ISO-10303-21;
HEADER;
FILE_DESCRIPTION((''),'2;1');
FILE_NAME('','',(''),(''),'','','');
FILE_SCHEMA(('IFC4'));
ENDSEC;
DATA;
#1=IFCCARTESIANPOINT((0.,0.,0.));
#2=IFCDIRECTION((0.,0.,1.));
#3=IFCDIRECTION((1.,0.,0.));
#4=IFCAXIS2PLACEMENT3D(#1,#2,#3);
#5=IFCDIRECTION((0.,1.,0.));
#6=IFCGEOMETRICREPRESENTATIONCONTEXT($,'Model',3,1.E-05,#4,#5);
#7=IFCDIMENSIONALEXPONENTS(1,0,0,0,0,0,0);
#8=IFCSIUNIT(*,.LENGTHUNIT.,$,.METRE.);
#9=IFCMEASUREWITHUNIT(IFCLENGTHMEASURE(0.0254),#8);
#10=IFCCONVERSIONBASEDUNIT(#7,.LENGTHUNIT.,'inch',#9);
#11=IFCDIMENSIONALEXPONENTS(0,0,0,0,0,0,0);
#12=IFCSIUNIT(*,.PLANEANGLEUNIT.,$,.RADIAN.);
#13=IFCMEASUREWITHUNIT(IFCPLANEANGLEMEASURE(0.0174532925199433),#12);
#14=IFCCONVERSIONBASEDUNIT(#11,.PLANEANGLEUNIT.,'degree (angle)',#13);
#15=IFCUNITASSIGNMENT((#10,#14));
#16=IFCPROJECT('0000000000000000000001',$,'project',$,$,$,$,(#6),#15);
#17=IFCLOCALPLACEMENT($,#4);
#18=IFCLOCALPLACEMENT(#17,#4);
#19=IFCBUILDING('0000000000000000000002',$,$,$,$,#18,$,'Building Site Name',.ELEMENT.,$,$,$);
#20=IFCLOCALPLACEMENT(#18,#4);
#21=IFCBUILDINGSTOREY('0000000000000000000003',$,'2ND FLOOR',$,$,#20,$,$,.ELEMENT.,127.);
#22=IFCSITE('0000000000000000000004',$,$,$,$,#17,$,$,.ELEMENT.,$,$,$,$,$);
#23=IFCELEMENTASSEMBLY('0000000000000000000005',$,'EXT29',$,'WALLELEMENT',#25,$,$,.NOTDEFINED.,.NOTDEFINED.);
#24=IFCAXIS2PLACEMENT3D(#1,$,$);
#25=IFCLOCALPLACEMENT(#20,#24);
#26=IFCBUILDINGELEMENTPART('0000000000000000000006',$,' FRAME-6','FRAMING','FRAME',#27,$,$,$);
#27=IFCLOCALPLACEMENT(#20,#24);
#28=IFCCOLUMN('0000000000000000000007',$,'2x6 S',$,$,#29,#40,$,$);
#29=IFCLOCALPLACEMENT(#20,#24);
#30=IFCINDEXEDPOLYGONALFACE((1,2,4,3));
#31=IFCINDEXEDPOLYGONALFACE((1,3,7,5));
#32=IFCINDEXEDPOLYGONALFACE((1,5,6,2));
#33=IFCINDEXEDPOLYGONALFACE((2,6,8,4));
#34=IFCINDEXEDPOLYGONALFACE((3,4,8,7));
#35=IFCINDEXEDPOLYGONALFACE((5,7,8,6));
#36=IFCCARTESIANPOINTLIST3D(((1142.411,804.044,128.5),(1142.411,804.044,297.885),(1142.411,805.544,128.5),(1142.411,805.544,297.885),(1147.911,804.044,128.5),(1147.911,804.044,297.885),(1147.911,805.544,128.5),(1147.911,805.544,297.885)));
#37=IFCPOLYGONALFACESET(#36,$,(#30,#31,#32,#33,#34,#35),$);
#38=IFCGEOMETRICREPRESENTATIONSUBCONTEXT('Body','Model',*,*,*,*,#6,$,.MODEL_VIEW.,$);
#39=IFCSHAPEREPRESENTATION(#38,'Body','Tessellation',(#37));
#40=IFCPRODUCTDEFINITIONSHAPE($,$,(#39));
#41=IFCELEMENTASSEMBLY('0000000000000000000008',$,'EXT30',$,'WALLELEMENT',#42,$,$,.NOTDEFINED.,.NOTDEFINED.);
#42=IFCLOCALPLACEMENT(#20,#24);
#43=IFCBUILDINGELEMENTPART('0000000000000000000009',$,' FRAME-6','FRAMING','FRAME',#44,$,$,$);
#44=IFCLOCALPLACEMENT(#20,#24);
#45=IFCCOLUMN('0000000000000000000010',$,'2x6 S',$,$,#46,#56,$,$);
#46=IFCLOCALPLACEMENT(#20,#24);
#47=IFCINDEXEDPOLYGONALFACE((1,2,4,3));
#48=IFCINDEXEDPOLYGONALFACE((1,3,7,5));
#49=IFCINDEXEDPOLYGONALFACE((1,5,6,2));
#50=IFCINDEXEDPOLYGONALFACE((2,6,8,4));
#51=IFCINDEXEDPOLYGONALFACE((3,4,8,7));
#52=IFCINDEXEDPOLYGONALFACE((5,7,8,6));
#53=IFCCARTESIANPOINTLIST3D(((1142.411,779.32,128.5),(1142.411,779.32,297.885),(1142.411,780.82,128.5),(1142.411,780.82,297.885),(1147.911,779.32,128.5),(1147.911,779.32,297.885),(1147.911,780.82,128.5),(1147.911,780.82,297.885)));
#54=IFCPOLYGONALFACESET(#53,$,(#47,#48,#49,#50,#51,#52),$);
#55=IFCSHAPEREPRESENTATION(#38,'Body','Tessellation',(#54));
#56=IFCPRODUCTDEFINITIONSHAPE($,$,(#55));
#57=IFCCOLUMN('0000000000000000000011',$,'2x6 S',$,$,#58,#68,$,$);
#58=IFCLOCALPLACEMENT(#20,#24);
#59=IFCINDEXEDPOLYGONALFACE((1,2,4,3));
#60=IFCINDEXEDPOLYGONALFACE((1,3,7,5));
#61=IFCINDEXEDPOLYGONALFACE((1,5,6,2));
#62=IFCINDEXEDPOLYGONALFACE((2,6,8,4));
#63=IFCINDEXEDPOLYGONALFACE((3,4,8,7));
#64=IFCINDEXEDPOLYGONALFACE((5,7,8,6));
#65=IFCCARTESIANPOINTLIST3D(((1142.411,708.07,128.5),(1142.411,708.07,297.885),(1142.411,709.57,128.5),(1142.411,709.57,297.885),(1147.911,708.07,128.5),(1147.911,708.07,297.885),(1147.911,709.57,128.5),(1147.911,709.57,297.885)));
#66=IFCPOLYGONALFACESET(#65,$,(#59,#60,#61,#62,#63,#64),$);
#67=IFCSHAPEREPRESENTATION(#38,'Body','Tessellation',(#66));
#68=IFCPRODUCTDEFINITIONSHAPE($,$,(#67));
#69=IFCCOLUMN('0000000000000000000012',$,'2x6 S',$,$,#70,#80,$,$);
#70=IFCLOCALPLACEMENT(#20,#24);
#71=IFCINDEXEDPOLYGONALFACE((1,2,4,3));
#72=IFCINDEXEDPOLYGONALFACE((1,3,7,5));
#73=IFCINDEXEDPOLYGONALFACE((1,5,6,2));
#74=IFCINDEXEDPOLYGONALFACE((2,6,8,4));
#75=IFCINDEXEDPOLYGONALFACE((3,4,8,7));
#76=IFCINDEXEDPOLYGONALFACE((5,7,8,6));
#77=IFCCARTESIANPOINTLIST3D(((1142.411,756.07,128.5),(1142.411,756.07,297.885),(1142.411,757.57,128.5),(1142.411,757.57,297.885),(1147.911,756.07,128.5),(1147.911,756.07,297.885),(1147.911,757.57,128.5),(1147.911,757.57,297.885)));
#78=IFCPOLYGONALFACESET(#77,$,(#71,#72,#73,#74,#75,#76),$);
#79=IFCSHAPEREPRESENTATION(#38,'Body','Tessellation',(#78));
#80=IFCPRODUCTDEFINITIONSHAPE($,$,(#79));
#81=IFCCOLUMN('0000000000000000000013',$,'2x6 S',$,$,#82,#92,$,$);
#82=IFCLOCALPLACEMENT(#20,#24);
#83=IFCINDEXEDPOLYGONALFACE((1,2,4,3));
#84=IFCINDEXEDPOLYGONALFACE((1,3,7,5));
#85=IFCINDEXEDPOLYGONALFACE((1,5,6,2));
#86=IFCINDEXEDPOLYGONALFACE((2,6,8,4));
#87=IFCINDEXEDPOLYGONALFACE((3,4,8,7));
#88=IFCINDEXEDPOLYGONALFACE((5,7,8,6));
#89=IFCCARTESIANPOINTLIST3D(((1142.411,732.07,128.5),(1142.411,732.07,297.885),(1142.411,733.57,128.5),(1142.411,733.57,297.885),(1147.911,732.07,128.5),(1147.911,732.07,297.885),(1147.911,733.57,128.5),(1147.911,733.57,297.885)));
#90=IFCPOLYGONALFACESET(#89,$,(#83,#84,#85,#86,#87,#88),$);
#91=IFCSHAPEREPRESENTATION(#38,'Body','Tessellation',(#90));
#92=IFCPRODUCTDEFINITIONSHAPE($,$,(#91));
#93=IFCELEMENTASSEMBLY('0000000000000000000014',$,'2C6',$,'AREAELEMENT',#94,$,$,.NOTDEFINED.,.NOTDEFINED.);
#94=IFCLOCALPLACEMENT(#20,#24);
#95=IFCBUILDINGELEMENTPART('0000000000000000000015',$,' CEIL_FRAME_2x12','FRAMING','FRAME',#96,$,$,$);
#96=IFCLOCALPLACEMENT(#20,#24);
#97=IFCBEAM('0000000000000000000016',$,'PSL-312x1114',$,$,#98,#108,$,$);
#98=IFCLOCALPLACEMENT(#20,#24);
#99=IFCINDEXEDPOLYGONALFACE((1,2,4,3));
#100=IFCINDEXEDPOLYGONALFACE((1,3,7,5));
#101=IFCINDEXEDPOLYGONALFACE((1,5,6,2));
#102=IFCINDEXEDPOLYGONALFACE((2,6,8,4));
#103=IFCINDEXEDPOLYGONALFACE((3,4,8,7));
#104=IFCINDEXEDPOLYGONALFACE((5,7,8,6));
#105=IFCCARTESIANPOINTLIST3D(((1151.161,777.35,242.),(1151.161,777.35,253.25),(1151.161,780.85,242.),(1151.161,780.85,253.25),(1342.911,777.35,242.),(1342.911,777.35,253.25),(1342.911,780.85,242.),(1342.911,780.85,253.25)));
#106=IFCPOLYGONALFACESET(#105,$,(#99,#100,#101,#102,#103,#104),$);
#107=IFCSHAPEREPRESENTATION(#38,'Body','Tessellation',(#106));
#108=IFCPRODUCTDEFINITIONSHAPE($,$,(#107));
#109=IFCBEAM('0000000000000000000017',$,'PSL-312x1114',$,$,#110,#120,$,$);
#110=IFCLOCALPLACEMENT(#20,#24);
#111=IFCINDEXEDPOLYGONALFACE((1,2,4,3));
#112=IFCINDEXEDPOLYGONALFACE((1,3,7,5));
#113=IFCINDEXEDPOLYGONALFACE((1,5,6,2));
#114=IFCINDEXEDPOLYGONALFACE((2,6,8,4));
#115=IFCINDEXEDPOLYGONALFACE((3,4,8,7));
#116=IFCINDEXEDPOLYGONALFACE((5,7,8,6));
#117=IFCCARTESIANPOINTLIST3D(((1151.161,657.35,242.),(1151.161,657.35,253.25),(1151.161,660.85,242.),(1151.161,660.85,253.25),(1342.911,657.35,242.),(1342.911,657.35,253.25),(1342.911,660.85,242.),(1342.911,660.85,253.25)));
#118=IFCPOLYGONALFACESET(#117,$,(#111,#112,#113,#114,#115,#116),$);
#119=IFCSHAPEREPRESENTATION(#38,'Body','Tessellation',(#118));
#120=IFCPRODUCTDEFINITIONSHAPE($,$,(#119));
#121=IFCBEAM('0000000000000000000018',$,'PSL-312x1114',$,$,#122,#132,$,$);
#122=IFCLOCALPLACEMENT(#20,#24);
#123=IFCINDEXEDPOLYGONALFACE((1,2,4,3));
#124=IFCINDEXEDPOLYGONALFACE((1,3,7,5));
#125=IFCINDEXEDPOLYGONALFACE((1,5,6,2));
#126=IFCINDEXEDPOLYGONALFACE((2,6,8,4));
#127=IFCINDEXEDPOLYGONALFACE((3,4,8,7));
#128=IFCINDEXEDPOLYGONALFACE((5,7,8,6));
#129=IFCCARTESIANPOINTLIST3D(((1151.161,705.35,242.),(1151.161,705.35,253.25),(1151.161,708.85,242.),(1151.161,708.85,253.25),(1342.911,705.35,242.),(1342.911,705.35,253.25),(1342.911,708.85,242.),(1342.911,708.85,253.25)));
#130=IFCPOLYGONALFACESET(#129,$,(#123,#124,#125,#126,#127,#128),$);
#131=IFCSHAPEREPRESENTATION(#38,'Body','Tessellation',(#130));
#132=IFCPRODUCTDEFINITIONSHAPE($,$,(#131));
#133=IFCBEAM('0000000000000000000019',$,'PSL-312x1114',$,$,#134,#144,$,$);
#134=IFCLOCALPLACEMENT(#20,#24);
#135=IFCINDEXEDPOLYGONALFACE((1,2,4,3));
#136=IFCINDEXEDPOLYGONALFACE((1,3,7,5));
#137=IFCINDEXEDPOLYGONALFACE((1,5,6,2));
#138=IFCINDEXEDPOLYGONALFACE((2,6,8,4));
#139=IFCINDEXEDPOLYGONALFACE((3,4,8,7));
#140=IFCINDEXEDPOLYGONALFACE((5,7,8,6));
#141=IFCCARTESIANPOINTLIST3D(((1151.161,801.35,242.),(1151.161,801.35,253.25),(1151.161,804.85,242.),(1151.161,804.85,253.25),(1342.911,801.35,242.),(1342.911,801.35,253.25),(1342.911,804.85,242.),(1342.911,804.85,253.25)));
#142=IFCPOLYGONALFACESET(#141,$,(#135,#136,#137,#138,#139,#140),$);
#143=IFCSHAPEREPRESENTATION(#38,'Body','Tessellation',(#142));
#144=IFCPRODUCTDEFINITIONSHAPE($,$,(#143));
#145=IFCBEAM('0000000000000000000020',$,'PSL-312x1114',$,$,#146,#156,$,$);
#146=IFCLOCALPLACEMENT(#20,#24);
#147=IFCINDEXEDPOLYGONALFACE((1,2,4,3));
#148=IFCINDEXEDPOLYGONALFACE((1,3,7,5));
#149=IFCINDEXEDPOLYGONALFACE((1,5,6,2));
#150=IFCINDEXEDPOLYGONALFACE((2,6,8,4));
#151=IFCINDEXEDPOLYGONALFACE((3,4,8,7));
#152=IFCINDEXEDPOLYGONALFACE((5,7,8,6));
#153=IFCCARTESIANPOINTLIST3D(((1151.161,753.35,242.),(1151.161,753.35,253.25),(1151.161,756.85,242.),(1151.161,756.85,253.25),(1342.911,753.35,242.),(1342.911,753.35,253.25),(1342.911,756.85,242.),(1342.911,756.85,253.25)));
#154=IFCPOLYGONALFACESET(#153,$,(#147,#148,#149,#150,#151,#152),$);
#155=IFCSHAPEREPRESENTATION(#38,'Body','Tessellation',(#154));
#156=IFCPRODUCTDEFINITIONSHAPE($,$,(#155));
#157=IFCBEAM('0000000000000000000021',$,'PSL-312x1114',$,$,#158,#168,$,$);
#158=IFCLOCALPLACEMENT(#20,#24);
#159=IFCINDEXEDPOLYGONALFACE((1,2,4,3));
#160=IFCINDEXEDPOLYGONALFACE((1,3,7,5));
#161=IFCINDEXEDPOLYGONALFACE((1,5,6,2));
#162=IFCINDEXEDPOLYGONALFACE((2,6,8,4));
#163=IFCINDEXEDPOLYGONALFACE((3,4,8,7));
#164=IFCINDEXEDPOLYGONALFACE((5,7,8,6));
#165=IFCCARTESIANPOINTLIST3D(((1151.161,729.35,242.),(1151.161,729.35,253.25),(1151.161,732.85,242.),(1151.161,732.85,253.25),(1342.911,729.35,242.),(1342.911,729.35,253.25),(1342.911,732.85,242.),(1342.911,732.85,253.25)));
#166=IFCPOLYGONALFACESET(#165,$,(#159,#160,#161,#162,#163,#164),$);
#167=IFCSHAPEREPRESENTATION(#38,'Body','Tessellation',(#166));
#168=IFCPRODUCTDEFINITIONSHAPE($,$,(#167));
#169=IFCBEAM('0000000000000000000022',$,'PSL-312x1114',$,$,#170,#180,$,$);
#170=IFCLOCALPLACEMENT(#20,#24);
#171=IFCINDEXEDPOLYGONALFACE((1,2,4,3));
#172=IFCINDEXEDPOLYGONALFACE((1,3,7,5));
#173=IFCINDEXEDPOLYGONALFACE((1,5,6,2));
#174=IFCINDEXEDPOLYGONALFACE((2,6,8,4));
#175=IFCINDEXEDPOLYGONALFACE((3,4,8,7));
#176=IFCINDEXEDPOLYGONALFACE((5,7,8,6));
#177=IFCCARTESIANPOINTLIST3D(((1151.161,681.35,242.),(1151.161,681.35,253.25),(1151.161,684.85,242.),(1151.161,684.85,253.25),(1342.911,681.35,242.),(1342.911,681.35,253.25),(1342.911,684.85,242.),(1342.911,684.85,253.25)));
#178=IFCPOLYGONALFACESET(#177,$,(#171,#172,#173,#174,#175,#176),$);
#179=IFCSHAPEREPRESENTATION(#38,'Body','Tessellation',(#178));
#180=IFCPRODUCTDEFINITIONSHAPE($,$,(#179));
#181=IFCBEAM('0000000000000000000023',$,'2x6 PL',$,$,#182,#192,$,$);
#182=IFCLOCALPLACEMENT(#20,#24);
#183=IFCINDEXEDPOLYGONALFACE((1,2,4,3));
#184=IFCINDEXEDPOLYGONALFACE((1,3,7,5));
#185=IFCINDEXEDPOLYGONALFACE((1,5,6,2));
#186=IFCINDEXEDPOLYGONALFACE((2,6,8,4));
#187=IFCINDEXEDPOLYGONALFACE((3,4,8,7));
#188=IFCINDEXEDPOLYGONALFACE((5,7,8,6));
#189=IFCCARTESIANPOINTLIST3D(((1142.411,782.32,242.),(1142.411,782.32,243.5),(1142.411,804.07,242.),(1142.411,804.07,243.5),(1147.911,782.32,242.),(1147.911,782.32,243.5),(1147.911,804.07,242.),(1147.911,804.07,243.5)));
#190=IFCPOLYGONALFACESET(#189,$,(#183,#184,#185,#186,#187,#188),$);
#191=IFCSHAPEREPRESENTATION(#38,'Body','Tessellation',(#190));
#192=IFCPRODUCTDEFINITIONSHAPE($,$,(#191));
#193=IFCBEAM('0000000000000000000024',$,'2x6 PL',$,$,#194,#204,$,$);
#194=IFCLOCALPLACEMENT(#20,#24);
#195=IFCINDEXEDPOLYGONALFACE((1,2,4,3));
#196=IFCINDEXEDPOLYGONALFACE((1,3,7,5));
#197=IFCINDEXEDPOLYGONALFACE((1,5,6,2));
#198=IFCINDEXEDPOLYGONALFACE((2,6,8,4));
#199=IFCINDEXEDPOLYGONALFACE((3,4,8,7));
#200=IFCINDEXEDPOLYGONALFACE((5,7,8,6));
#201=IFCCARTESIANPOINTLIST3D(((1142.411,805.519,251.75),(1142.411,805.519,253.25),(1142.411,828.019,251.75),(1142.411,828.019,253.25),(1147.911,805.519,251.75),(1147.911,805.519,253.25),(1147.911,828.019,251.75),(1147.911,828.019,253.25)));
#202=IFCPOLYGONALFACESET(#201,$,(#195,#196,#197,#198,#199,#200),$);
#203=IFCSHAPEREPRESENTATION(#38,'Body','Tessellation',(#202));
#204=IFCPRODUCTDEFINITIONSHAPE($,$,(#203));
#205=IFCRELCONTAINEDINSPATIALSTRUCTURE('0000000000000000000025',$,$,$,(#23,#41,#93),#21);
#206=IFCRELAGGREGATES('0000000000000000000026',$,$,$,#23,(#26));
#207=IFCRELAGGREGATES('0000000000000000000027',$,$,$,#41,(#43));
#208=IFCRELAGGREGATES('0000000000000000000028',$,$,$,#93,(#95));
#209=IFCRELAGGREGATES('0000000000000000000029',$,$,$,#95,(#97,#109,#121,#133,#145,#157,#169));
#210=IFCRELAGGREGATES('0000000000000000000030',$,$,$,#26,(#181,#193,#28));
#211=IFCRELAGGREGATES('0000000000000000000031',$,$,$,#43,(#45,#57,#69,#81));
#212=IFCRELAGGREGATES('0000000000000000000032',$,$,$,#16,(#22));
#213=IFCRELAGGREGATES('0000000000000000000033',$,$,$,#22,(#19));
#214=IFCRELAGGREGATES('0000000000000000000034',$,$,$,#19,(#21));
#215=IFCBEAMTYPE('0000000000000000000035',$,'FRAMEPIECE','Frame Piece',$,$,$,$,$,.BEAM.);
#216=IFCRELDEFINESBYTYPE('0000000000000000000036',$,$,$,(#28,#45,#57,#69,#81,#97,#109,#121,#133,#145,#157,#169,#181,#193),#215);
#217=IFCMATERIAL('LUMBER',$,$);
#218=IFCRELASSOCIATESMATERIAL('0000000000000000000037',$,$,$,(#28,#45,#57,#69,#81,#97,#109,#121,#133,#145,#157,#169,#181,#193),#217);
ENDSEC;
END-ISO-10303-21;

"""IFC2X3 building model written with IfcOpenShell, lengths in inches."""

from ifc_helpers import new_model, entity, si_unit, converted_unit, direction, frame, frame_2d, origin_with_axes, place, context, subcontext, project, spatial, rectangle, extrude, material, type_object, element, aggregate, save


model = new_model("IFC2X3")

# Units and contexts
model_context = context("Model", 3, precision=1e-05, world=origin_with_axes(), true_north=direction((0.0, 1.0, 0.0)))
body_context = subcontext(model_context, "Body", "Model", "MODEL_VIEW")
ifc_project = project(units=[converted_unit("LENGTHUNIT", "inch", entity("IfcLengthMeasure", 0.0254), si_unit("LENGTHUNIT", "METRE"), dimensions=[1, 0, 0, 0, 0, 0, 0]), converted_unit("PLANEANGLEUNIT", "degree (angle)", entity("IfcPlaneAngleMeasure", 0.0174532925199433), si_unit("PLANEANGLEUNIT", "RADIAN"), dimensions=[0, 0, 0, 0, 0, 0, 0])], contexts=[model_context])

# Site, building, storey
site_placement = place(None, origin_with_axes())
site = spatial("IfcSite", under=ifc_project, at=site_placement, CompositionType="ELEMENT")
building_placement = place(site_placement, origin_with_axes())
building = spatial("IfcBuilding", under=site, at=building_placement, LongName="Building Site Name", CompositionType="ELEMENT")
storey_placement = place(building_placement, origin_with_axes())
storey = spatial("IfcBuildingStorey", under=building, at=storey_placement, Name="2ND FLOOR", CompositionType="ELEMENT", Elevation=127.0)

# Element assembly, building element part, column
assembly_1_placement = place(storey_placement, origin_with_axes())
assembly_1 = element("IfcElementAssembly", 1, at=assembly_1_placement, inside=storey, Name="EXT29", ObjectType="WALLELEMENT", AssemblyPlace="NOTDEFINED", PredefinedType="NOTDEFINED")
building_element_part_1 = element("IfcBuildingElementPart", 2, Name=" FRAME-6", Description="FRAMING", ObjectType="FRAME")
aggregate(assembly_1, [building_element_part_1])
ifc_material = material(Name="LUMBER")
beam_type = type_object("IfcBeamType", Name="FRAMEPIECE", Description="Frame Piece", PredefinedType="BEAM")
column_1_placement = place(assembly_1_placement, frame((1145.161, 804.794, 297.885), z_axis=(0.0, 0.0, -1.0), x_axis=(0.0, -1.0, 0.0)))
column_1 = element("IfcColumn", 3, at=column_1_placement, type_object=beam_type, material=ifc_material, Name="2x6 S", context=body_context, shape_type="SweptSolid", body=[
    extrude(rectangle(XDim=1.5, YDim=5.5, at=frame_2d((0.0, 0.0), x_axis=(-1.0, 0.0))), origin_with_axes(), (0.0, 0.0, 1.0), 169.385),
])

# Element assembly, building element part, columns
assembly_2_placement = place(storey_placement, origin_with_axes())
assembly_2 = element("IfcElementAssembly", 4, at=assembly_2_placement, inside=storey, Name="EXT30", ObjectType="WALLELEMENT", AssemblyPlace="NOTDEFINED", PredefinedType="NOTDEFINED")
building_element_part_2 = element("IfcBuildingElementPart", 5, Name=" FRAME-6", Description="FRAMING", ObjectType="FRAME")
aggregate(assembly_2, [building_element_part_2])
column_2_placement = place(assembly_2_placement, frame((1145.161, 780.07, 297.885), z_axis=(0.0, 0.0, -1.0), x_axis=(0.0, -1.0, 0.0)))
column_2 = element("IfcColumn", 6, at=column_2_placement, type_object=beam_type, material=ifc_material, Name="2x6 S", context=body_context, shape_type="SweptSolid", body=[
    extrude(rectangle(XDim=1.5, YDim=5.5, at=frame_2d((0.0, 0.0), x_axis=(-1.0, 0.0))), origin_with_axes(), (0.0, 0.0, 1.0), 169.385),
])
column_3_placement = place(assembly_2_placement, frame((1145.161, 708.82, 297.885), z_axis=(0.0, 0.0, -1.0), x_axis=(0.0, -1.0, 0.0)))
column_3 = element("IfcColumn", 7, at=column_3_placement, type_object=beam_type, material=ifc_material, Name="2x6 S", context=body_context, shape_type="SweptSolid", body=[
    extrude(rectangle(XDim=1.5, YDim=5.5, at=frame_2d((0.0, 0.0), x_axis=(-1.0, 0.0))), origin_with_axes(), (0.0, 0.0, 1.0), 169.385),
])
column_4_placement = place(assembly_2_placement, frame((1145.161, 756.82, 297.885), z_axis=(0.0, 0.0, -1.0), x_axis=(0.0, -1.0, 0.0)))
column_4 = element("IfcColumn", 8, at=column_4_placement, type_object=beam_type, material=ifc_material, Name="2x6 S", context=body_context, shape_type="SweptSolid", body=[
    extrude(rectangle(XDim=1.5, YDim=5.5, at=frame_2d((0.0, 0.0), x_axis=(-1.0, 0.0))), origin_with_axes(), (0.0, 0.0, 1.0), 169.385),
])
column_5_placement = place(assembly_2_placement, frame((1145.161, 732.82, 297.885), z_axis=(0.0, 0.0, -1.0), x_axis=(0.0, -1.0, 0.0)))
column_5 = element("IfcColumn", 9, at=column_5_placement, type_object=beam_type, material=ifc_material, Name="2x6 S", context=body_context, shape_type="SweptSolid", body=[
    extrude(rectangle(XDim=1.5, YDim=5.5, at=frame_2d((0.0, 0.0), x_axis=(-1.0, 0.0))), origin_with_axes(), (0.0, 0.0, 1.0), 169.385),
])

# Element assembly, building element part, beams
assembly_3_placement = place(storey_placement, origin_with_axes())
assembly_3 = element("IfcElementAssembly", 10, at=assembly_3_placement, inside=storey, Name="2C6", ObjectType="AREAELEMENT", AssemblyPlace="NOTDEFINED", PredefinedType="NOTDEFINED")
building_element_part_3 = element("IfcBuildingElementPart", 11, Name=" CEIL_FRAME_2x12", Description="FRAMING", ObjectType="FRAME")
aggregate(assembly_3, [building_element_part_3])
beam_1_placement = place(assembly_3_placement, frame((1151.161, 779.1, 247.625), z_axis=(1.0, 0.0, 0.0), x_axis=(0.0, 1.0, 0.0)))
beam_1 = element("IfcBeam", 12, at=beam_1_placement, type_object=beam_type, material=ifc_material, Name="PSL-312x1114", context=body_context, shape_type="SweptSolid", body=[
    extrude(rectangle(XDim=3.5, YDim=11.25, at=frame_2d((0.0, 0.0), x_axis=(-1.0, 0.0))), origin_with_axes(), (0.0, 0.0, 1.0), 191.75),
])
beam_2_placement = place(assembly_3_placement, frame((1151.161, 659.1, 247.625), z_axis=(1.0, 0.0, 0.0), x_axis=(0.0, 1.0, 0.0)))
beam_2 = element("IfcBeam", 13, at=beam_2_placement, type_object=beam_type, material=ifc_material, Name="PSL-312x1114", context=body_context, shape_type="SweptSolid", body=[
    extrude(rectangle(XDim=3.5, YDim=11.25, at=frame_2d((0.0, 0.0), x_axis=(-1.0, 0.0))), origin_with_axes(), (0.0, 0.0, 1.0), 191.75),
])
beam_3_placement = place(assembly_3_placement, frame((1151.161, 707.1, 247.625), z_axis=(1.0, 0.0, 0.0), x_axis=(0.0, 1.0, 0.0)))
beam_3 = element("IfcBeam", 14, at=beam_3_placement, type_object=beam_type, material=ifc_material, Name="PSL-312x1114", context=body_context, shape_type="SweptSolid", body=[
    extrude(rectangle(XDim=3.5, YDim=11.25, at=frame_2d((0.0, 0.0), x_axis=(-1.0, 0.0))), origin_with_axes(), (0.0, 0.0, 1.0), 191.75),
])
beam_4_placement = place(assembly_3_placement, frame((1151.161, 803.1, 247.625), z_axis=(1.0, 0.0, 0.0), x_axis=(0.0, 1.0, 0.0)))
beam_4 = element("IfcBeam", 15, at=beam_4_placement, type_object=beam_type, material=ifc_material, Name="PSL-312x1114", context=body_context, shape_type="SweptSolid", body=[
    extrude(rectangle(XDim=3.5, YDim=11.25, at=frame_2d((0.0, 0.0), x_axis=(-1.0, 0.0))), origin_with_axes(), (0.0, 0.0, 1.0), 191.75),
])
beam_5_placement = place(assembly_3_placement, frame((1151.161, 755.1, 247.625), z_axis=(1.0, 0.0, 0.0), x_axis=(0.0, 1.0, 0.0)))
beam_5 = element("IfcBeam", 16, at=beam_5_placement, type_object=beam_type, material=ifc_material, Name="PSL-312x1114", context=body_context, shape_type="SweptSolid", body=[
    extrude(rectangle(XDim=3.5, YDim=11.25, at=frame_2d((0.0, 0.0), x_axis=(-1.0, 0.0))), origin_with_axes(), (0.0, 0.0, 1.0), 191.75),
])
beam_6_placement = place(assembly_3_placement, frame((1151.161, 731.1, 247.625), z_axis=(1.0, 0.0, 0.0), x_axis=(0.0, 1.0, 0.0)))
beam_6 = element("IfcBeam", 17, at=beam_6_placement, type_object=beam_type, material=ifc_material, Name="PSL-312x1114", context=body_context, shape_type="SweptSolid", body=[
    extrude(rectangle(XDim=3.5, YDim=11.25, at=frame_2d((0.0, 0.0), x_axis=(-1.0, 0.0))), origin_with_axes(), (0.0, 0.0, 1.0), 191.75),
])
beam_7_placement = place(assembly_3_placement, frame((1151.161, 683.1, 247.625), z_axis=(1.0, 0.0, 0.0), x_axis=(0.0, 1.0, 0.0)))
beam_7 = element("IfcBeam", 18, at=beam_7_placement, type_object=beam_type, material=ifc_material, Name="PSL-312x1114", context=body_context, shape_type="SweptSolid", body=[
    extrude(rectangle(XDim=3.5, YDim=11.25, at=frame_2d((0.0, 0.0), x_axis=(-1.0, 0.0))), origin_with_axes(), (0.0, 0.0, 1.0), 191.75),
])
aggregate(building_element_part_3, [beam_1, beam_2, beam_3, beam_4, beam_5, beam_6, beam_7])

# Beams
beam_8_placement = place(assembly_1_placement, frame((1145.161, 782.32, 242.75), z_axis=(0.0, 1.0, 0.0), x_axis=(0.0, 0.0, -1.0)))
beam_8 = element("IfcBeam", 19, at=beam_8_placement, type_object=beam_type, material=ifc_material, Name="2x6 PL", context=body_context, shape_type="SweptSolid", body=[
    extrude(rectangle(XDim=1.5, YDim=5.5, at=frame_2d((0.0, 0.0), x_axis=(-1.0, 0.0))), origin_with_axes(), (0.0, 0.0, 1.0), 21.75),
])
beam_9_placement = place(assembly_1_placement, frame((1145.161, 805.519, 252.5), z_axis=(0.0, 1.0, 0.0), x_axis=(0.0, 0.0, -1.0)))
beam_9 = element("IfcBeam", 20, at=beam_9_placement, type_object=beam_type, material=ifc_material, Name="2x6 PL", context=body_context, shape_type="SweptSolid", body=[
    extrude(rectangle(XDim=1.5, YDim=5.5, at=frame_2d((0.0, 0.0), x_axis=(-1.0, 0.0))), origin_with_axes(), (0.0, 0.0, 1.0), 22.5),
])
aggregate(building_element_part_1, [beam_8, beam_9, column_1])
aggregate(building_element_part_2, [column_2, column_3, column_4, column_5])

save(model, "model.ifc")
